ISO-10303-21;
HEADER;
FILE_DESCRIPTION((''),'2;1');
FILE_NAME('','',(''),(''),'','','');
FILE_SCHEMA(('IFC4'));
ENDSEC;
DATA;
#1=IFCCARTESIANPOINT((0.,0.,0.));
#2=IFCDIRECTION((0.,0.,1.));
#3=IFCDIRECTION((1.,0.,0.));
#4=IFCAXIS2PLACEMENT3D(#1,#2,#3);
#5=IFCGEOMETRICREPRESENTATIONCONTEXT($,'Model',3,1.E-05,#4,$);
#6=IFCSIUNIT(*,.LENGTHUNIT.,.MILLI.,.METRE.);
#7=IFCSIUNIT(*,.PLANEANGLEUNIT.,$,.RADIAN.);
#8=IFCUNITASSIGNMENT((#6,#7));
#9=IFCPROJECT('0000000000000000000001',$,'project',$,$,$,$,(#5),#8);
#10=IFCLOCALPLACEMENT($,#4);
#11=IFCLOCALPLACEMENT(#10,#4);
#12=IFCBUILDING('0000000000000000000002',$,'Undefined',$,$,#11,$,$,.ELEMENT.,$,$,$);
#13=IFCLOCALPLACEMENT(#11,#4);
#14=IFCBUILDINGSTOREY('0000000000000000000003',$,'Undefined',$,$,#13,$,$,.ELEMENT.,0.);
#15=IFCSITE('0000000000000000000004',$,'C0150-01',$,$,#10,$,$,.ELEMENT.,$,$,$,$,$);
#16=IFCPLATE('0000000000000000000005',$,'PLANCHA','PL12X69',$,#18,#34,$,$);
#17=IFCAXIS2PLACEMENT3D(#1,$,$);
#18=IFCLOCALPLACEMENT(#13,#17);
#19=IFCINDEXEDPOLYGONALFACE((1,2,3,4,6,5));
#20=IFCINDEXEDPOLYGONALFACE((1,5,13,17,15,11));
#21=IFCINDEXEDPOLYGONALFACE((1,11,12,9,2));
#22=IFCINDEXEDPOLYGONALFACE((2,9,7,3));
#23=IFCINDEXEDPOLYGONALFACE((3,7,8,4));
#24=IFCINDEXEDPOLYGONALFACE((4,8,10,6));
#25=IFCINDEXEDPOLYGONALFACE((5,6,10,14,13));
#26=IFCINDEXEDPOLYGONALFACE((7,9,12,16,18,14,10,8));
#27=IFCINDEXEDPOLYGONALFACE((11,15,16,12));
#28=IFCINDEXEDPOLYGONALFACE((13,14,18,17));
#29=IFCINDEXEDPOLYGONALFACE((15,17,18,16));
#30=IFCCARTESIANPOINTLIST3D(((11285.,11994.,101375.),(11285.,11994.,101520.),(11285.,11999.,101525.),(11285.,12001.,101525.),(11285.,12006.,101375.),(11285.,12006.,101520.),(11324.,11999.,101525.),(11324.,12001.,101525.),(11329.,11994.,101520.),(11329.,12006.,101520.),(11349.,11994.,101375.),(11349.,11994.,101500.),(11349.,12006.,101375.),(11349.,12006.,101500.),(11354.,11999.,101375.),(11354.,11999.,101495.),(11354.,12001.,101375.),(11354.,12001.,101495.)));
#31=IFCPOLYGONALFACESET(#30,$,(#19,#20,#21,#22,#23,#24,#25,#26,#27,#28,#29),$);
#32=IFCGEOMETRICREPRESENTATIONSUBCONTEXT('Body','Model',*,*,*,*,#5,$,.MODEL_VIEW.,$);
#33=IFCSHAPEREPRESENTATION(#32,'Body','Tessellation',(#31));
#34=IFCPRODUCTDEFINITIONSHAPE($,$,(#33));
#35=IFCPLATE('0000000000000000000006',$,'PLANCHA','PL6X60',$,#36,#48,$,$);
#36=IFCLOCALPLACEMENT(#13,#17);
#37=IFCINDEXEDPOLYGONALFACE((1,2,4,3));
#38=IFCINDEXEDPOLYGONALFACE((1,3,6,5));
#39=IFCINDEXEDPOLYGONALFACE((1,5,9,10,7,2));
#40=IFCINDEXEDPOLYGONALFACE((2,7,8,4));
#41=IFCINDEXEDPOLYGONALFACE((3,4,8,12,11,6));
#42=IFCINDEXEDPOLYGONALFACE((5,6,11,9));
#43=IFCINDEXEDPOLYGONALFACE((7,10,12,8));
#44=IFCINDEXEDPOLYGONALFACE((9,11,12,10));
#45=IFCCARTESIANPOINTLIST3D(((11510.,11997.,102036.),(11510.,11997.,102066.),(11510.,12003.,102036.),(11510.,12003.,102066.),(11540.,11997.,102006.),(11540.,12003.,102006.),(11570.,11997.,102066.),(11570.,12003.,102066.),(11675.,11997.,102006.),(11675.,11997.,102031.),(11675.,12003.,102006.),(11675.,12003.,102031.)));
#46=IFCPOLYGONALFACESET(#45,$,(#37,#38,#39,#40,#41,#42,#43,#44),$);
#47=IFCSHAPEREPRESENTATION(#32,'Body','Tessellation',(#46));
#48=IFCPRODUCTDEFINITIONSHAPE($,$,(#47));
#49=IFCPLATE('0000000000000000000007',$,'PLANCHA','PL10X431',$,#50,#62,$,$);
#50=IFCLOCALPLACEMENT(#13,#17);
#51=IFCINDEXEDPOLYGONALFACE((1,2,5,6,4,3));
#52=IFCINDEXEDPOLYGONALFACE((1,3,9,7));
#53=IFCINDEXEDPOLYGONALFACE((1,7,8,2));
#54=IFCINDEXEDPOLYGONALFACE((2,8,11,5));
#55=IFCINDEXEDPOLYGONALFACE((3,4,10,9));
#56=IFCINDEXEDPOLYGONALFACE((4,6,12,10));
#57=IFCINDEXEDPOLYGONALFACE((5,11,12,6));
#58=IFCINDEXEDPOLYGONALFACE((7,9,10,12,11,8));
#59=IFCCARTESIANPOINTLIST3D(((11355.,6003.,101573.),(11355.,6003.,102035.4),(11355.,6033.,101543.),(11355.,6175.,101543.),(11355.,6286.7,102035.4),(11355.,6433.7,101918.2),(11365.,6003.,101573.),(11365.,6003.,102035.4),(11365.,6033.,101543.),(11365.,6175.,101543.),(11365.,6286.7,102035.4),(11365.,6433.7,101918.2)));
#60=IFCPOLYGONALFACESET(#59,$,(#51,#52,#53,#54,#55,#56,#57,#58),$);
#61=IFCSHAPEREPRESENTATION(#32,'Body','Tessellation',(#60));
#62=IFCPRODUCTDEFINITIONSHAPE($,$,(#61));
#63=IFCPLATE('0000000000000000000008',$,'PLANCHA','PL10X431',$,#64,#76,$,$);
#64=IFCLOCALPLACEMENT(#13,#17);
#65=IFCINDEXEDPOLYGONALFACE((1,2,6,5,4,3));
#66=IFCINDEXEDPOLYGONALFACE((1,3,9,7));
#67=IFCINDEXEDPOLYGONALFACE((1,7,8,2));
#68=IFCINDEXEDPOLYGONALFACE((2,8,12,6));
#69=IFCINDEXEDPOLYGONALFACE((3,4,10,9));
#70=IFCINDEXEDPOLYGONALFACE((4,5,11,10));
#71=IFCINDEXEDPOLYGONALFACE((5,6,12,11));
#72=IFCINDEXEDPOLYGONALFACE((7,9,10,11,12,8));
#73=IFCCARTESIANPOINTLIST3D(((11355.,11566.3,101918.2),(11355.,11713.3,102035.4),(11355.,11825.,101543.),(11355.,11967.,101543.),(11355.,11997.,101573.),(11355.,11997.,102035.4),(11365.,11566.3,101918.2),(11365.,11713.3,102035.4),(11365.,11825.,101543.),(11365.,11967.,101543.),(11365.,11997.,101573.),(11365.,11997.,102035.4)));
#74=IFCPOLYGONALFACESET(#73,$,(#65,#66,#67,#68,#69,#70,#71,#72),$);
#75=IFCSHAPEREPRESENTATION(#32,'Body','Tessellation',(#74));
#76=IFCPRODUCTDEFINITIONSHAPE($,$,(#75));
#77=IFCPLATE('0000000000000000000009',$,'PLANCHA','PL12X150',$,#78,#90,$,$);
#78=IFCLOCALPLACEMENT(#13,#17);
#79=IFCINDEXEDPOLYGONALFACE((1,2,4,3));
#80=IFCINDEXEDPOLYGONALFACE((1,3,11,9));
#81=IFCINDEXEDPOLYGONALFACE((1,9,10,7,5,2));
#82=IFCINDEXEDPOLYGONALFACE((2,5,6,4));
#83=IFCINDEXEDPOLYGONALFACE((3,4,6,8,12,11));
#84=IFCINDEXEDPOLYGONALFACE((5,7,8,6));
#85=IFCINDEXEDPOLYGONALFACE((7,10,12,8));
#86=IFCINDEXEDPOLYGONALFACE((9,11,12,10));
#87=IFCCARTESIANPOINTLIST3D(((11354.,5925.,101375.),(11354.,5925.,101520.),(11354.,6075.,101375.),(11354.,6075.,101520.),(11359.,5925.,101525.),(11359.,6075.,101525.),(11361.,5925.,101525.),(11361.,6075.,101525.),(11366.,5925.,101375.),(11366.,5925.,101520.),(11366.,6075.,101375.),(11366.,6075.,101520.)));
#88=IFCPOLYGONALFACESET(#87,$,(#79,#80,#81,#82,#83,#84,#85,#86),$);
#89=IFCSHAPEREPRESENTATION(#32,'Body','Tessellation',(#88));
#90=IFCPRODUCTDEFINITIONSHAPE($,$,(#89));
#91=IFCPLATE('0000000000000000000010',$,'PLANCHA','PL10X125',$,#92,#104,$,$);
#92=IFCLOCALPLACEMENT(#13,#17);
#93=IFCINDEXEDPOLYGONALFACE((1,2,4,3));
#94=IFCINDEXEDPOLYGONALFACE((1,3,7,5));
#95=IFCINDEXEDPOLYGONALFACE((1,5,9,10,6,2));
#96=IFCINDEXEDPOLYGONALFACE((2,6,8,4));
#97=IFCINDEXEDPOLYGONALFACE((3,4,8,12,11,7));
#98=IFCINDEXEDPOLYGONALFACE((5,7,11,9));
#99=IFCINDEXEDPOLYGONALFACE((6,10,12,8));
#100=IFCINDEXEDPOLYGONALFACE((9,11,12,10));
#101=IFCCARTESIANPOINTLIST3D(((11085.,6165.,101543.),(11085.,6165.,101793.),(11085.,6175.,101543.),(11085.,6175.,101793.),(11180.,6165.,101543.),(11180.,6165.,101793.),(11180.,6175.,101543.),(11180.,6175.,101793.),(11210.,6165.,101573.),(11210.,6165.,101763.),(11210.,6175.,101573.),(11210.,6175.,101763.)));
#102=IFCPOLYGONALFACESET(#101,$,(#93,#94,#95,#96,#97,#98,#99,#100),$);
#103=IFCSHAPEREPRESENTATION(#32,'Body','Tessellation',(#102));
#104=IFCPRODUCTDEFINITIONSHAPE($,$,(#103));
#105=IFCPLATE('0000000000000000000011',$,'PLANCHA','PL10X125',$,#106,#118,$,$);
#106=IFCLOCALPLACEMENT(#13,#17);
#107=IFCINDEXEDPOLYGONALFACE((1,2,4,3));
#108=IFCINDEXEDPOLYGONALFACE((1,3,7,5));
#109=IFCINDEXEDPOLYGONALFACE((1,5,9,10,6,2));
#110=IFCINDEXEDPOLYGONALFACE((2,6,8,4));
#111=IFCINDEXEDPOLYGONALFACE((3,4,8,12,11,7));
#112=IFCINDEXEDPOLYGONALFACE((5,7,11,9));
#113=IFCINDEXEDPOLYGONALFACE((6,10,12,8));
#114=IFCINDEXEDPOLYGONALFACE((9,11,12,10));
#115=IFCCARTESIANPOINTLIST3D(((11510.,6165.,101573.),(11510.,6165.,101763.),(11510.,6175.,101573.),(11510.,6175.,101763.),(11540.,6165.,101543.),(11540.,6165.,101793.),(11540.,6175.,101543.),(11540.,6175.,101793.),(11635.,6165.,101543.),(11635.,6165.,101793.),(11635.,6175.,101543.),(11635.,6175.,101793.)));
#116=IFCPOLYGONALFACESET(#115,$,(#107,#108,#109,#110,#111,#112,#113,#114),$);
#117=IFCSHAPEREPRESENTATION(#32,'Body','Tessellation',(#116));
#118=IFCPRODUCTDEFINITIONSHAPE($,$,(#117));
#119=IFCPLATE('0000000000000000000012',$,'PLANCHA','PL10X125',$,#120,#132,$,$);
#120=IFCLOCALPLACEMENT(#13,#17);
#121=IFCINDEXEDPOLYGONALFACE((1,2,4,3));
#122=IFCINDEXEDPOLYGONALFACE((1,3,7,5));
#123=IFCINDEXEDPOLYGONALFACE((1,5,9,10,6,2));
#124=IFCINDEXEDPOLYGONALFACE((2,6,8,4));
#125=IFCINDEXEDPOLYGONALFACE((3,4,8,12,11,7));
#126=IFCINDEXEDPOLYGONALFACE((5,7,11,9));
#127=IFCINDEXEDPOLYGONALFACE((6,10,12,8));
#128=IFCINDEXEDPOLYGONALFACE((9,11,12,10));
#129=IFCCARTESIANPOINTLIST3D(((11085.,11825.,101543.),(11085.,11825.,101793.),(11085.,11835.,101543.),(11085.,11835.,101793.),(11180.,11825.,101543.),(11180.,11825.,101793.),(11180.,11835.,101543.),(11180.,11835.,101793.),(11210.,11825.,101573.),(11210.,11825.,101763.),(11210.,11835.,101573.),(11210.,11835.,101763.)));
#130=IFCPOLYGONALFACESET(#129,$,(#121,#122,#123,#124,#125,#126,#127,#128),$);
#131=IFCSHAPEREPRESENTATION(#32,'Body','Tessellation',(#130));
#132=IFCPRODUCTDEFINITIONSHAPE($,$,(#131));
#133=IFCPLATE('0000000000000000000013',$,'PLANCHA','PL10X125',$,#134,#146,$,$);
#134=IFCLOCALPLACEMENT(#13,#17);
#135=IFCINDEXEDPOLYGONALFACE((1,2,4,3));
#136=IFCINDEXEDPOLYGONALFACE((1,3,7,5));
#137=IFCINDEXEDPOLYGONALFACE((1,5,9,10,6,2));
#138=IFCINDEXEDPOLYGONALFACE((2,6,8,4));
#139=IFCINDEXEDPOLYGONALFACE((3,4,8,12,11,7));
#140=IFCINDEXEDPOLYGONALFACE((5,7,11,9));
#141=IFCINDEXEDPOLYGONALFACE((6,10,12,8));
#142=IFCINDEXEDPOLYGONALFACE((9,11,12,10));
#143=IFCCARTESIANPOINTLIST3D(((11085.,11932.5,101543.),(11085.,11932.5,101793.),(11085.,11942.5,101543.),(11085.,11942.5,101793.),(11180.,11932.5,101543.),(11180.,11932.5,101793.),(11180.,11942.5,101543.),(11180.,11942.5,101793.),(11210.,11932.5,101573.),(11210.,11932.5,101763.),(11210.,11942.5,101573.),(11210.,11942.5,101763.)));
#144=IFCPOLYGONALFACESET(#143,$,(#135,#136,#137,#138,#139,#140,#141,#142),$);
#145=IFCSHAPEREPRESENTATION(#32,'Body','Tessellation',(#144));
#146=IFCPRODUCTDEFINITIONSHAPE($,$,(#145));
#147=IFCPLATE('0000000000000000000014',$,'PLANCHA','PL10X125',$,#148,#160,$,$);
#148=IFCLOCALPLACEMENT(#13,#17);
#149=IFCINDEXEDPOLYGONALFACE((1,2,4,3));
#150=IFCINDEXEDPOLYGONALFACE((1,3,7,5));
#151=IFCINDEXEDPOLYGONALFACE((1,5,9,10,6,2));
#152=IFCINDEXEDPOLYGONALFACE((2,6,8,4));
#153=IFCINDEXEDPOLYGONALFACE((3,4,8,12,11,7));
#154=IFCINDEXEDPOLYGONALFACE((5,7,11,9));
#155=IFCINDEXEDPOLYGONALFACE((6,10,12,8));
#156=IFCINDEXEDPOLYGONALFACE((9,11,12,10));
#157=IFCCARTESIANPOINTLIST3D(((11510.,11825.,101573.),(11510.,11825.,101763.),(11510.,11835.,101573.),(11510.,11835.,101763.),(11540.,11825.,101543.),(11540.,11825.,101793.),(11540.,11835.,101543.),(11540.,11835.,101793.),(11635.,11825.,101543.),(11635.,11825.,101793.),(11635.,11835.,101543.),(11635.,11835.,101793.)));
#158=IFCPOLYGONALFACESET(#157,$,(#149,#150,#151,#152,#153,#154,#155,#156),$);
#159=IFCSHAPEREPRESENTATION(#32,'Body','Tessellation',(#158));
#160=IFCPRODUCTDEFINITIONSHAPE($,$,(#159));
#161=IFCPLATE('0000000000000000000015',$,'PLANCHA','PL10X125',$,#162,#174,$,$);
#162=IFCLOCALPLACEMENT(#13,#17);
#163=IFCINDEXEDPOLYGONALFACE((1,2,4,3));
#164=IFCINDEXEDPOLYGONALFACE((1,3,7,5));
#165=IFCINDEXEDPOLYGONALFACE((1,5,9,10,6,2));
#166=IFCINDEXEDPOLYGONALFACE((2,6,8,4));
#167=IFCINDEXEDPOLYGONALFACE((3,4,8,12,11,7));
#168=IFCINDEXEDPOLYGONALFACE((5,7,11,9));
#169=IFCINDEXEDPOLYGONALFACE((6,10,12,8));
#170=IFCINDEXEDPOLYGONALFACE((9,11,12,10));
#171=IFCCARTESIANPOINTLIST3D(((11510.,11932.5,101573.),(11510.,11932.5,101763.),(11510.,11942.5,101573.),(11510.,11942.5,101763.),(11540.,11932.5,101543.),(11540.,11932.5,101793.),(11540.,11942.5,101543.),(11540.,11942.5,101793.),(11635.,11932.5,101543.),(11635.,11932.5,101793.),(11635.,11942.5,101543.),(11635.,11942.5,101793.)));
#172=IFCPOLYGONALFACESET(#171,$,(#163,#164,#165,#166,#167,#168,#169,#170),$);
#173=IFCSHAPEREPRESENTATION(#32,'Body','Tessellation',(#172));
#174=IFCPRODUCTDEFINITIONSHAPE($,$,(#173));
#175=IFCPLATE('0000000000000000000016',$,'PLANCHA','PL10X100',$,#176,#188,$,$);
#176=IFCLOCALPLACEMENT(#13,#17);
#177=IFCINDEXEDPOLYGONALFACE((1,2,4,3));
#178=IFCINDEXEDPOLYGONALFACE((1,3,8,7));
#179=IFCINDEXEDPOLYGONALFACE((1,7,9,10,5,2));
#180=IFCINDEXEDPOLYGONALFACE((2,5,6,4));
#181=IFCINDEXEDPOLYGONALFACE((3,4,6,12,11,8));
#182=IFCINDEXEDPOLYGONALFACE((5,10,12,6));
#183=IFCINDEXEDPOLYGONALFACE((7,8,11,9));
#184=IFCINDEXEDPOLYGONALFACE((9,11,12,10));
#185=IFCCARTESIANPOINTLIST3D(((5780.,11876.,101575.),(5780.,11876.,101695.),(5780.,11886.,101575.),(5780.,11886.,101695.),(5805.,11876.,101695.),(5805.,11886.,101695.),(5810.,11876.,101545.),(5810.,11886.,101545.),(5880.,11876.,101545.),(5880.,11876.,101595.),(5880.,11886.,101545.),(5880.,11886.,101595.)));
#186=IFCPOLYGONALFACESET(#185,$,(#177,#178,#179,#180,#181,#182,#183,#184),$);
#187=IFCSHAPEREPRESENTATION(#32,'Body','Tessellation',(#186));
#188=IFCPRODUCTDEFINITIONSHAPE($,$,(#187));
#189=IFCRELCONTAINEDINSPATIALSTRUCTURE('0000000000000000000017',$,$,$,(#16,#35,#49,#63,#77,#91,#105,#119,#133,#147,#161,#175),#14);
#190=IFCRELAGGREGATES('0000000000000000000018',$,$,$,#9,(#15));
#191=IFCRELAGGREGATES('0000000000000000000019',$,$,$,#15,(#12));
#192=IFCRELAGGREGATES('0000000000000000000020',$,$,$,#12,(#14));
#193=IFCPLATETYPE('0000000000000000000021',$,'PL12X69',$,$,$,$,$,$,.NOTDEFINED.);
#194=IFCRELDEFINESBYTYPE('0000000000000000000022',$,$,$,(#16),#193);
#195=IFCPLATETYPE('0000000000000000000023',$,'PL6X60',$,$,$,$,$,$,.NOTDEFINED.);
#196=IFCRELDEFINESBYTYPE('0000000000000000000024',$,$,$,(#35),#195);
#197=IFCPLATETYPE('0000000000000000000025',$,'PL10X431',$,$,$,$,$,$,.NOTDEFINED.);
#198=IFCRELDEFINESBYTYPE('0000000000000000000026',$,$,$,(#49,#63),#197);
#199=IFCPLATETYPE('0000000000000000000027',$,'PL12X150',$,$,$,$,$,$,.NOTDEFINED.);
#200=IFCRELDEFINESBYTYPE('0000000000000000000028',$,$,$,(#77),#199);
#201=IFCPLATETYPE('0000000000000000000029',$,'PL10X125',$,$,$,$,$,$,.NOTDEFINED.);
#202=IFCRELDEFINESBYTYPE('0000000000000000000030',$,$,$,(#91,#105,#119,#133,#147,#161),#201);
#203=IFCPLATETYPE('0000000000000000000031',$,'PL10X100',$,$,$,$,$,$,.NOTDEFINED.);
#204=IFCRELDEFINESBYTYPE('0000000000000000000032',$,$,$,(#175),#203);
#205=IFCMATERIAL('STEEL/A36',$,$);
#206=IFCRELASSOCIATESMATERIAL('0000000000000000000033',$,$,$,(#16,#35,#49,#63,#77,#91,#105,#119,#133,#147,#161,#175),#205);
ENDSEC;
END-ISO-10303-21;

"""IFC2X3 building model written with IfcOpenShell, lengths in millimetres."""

from ifc_helpers import new_model, si_unit, frame, origin_with_axes, place, context, subcontext, project, spatial, polyline, outline, extrude, boolean, material, type_object, element, save


model = new_model("IFC2X3")

# Units and contexts
model_context = context("Model", 3, precision=1e-05, world=origin_with_axes())
body_context = subcontext(model_context, "Body", "Model", "MODEL_VIEW")
ifc_project = project(units=[si_unit("LENGTHUNIT", "METRE", prefix="MILLI"), si_unit("PLANEANGLEUNIT", "RADIAN")], contexts=[model_context])

# Site, building, storey
site_placement = place(None, origin_with_axes())
site = spatial("IfcSite", under=ifc_project, at=site_placement, Name="C0150-01", CompositionType="ELEMENT")
building_placement = place(site_placement, origin_with_axes())
building = spatial("IfcBuilding", under=site, at=building_placement, Name="Undefined", CompositionType="ELEMENT")
storey_placement = place(building_placement, origin_with_axes())
storey = spatial("IfcBuildingStorey", under=building, at=storey_placement, Name="Undefined", CompositionType="ELEMENT", Elevation=0.0)

# Shared definitions
ifc_material_1 = material(Name="STEEL/A36")

# Plates
plate_type_1 = type_object("IfcPlateType", Name="PL12X69", PredefinedType="NOTDEFINED")
plate_1_placement = place(storey_placement, frame((11285.0, 12000.0, 101525.0), z_axis=(0.0, -1.0, 0.0), x_axis=(0.0, 0.0, -1.0)))
element("IfcPlate", 1, at=plate_1_placement, inside=storey, type_object=plate_type_1, material=ifc_material_1, Name="PLANCHA", Description="PL12X69", context=body_context, shape_type="CSG", body=[
    boolean("DIFFERENCE", boolean("DIFFERENCE", boolean("DIFFERENCE", boolean("DIFFERENCE", extrude(outline(polyline([(0.0, 0.0), (150.0, 0.0), (150.0, 69.0), (30.0, 69.0), (0.0, 39.0), (0.0, 0.0)])), frame((0.0, 0.0, -6.0), z_axis=(0.0, 0.0, 1.0), x_axis=(1.0, 0.0, 0.0)), (0.0, 0.0, 1.0), 12.0), extrude(outline(polyline([(0.0, 0.0), (5.0, 0.0), (5.0, 5.0), (0.0, 0.0)])), frame((152.5, 69.0, -1.0), z_axis=(-1.0, 0.0, 0.0), x_axis=(0.0, 0.0, -1.0)), (0.0, 0.0, 1.0), 155.0)), extrude(outline(polyline([(0.0, 0.0), (5.0, 0.0), (5.0, 5.0), (0.0, 0.0)])), frame((-2.5, 69.0, 1.0), z_axis=(1.0, 0.0, 0.0), x_axis=(0.0, 0.0, 1.0)), (0.0, 0.0, 1.0), 155.0)), extrude(outline(polyline([(0.0, 0.0), (5.0, 0.0), (5.0, 5.0), (0.0, 0.0)])), frame((0.0, 71.5, -1.0), z_axis=(0.0, -1.0, 0.0), x_axis=(0.0, 0.0, -1.0)), (0.0, 0.0, 1.0), 101.0)), extrude(outline(polyline([(0.0, 0.0), (5.0, 0.0), (5.0, 5.0), (0.0, 0.0)])), frame((0.0, -29.5, 1.0), z_axis=(0.0, 1.0, 0.0), x_axis=(0.0, 0.0, 1.0)), (0.0, 0.0, 1.0), 101.0)),
])
plate_type_2 = type_object("IfcPlateType", Name="PL6X60", PredefinedType="NOTDEFINED")
plate_2_placement = place(storey_placement, frame((11675.0, 12000.0, 102031.0), z_axis=(0.0, 1.0, 0.0), x_axis=(0.000005, 0.0, -1.0)))
element("IfcPlate", 2, at=plate_2_placement, inside=storey, type_object=plate_type_2, material=ifc_material_1, Name="PLANCHA", Description="PL6X60", context=body_context, shape_type="SweptSolid", body=[
    extrude(outline(polyline([(0.0, 0.0), (25.0, 0.0), (25.0, 135.0), (-5.0, 165.0), (-35.0, 165.0), (-35.0, 105.0), (0.0, 0.0)])), frame((0.0, 0.0, -3.0), z_axis=(0.0, 0.0, 1.0), x_axis=(1.0, 0.0, 0.0)), (0.0, 0.0, 1.0), 6.0),
])
plate_type_3 = type_object("IfcPlateType", Name="PL10X431", PredefinedType="NOTDEFINED")
for number, where, z_axis, x_axis, name in (
    (3, (11360.0, 6433.7, 101918.2), (-1.0, 0.0, 0.0), (0.0, -0.567638, -0.823279), "PLANCHA"),
    (4, (11360.0, 11566.3, 101918.2), (1.0, 0.0, 0.0), (0.0, 0.567638, -0.823279), "PLANCHA"),
):
    element("IfcPlate", number, at=place(storey_placement, frame(where, z_axis=z_axis, x_axis=x_axis)), inside=storey, type_object=plate_type_3, material=ifc_material_1, Name=name, Description="PL10X431", context=body_context, shape_type="SweptSolid", body=[
        extrude(outline(polyline([(0.0, 0.0), (455.8, 0.0), (536.4, 116.9), (528.7, 158.6), (148.0, 421.1), (-13.0, 187.5), (0.0, 0.0)])), frame((0.0, 0.0, -5.0), z_axis=(0.0, 0.0, 1.0), x_axis=(1.0, 0.0, 0.0)), (0.0, 0.0, 1.0), 10.0),
    ])
plate_type_4 = type_object("IfcPlateType", Name="PL12X150", PredefinedType="NOTDEFINED")
plate_3_placement = place(storey_placement, frame((11360.0, 6075.0, 101525.0), z_axis=(-1.0, 0.0, 0.0), x_axis=(0.0, 0.0, -1.0)))
element("IfcPlate", 5, at=plate_3_placement, inside=storey, type_object=plate_type_4, material=ifc_material_1, Name="PLANCHA", Description="PL12X150", context=body_context, shape_type="CSG", body=[
    boolean("DIFFERENCE", boolean("DIFFERENCE", extrude(outline(polyline([(0.0, 0.0), (150.0, 0.0), (150.0, 150.0), (0.0, 150.0), (0.0, 0.0)])), frame((0.0, 0.0, -6.0), z_axis=(0.0, 0.0, 1.0), x_axis=(1.0, 0.0, 0.0)), (0.0, 0.0, 1.0), 12.0), extrude(outline(polyline([(0.0, 0.0), (5.0, 0.0), (5.0, 5.0), (0.0, 0.0)])), frame((5.0, 152.5, 6.0), z_axis=(0.0, -1.0, 0.0), x_axis=(-1.0, 0.0, 0.0)), (0.0, 0.0, 1.0), 155.0)), extrude(outline(polyline([(0.0, 0.0), (5.0, 0.0), (5.0, 5.0), (0.0, 0.0)])), frame((5.0, -2.5, -6.0), z_axis=(0.0, 1.0, 0.0), x_axis=(-1.0, 0.0, 0.0)), (0.0, 0.0, 1.0), 155.0)),
])
plate_type_5 = type_object("IfcPlateType", Name="PL10X125", PredefinedType="NOTDEFINED")
for number, where, z_axis, x_axis, name in (
    (6, (11085.0, 6170.0, 101793.0), (0.0, -1.0, 0.0), (0.0, 0.0, -1.0), "PLANCHA"),
    (7, (11635.0, 6170.0, 101793.0), (0.0, 1.0, 0.0), (0.0, 0.0, -1.0), "PLANCHA"),
    (8, (11085.0, 11830.0, 101793.0), (0.0, -1.0, 0.0), (0.0, 0.0, -1.0), "PLANCHA"),
    (9, (11085.0, 11937.5, 101793.0), (0.0, -1.0, 0.0), (0.0, 0.0, -1.0), "PLANCHA"),
    (10, (11635.0, 11830.0, 101793.0), (0.0, 1.0, 0.0), (0.0, 0.0, -1.0), "PLANCHA"),
    (11, (11635.0, 11937.5, 101793.0), (0.0, 1.0, 0.0), (0.0, 0.0, -1.0), "PLANCHA"),
):
    element("IfcPlate", number, at=place(storey_placement, frame(where, z_axis=z_axis, x_axis=x_axis)), inside=storey, type_object=plate_type_5, material=ifc_material_1, Name=name, Description="PL10X125", context=body_context, shape_type="SweptSolid", body=[
        extrude(outline(polyline([(0.0, 0.0), (250.0, 0.0), (250.0, 95.0), (220.0, 125.0), (30.0, 125.0), (0.0, 95.0), (0.0, 0.0)])), frame((0.0, 0.0, -5.0), z_axis=(0.0, 0.0, 1.0), x_axis=(1.0, 0.0, 0.0)), (0.0, 0.0, 1.0), 10.0),
    ])
plate_type_6 = type_object("IfcPlateType", Name="PL10X100", PredefinedType="NOTDEFINED")
plate_4_placement = place(storey_placement, frame((5880.0, 11881.0, 101545.0), z_axis=(0.0, 1.0, 0.0), x_axis=(-1.0, 0.0, 0.0)))
element("IfcPlate", 12, at=plate_4_placement, inside=storey, type_object=plate_type_6, material=ifc_material_1, Name="PLANCHA", Description="PL10X100", context=body_context, shape_type="SweptSolid", body=[
    extrude(outline(polyline([(0.0, 0.0), (70.0, 0.0), (100.0, 30.0), (100.0, 150.0), (75.0, 150.0), (0.0, 50.0), (0.0, 0.0)])), frame((0.0, 0.0, -5.0), z_axis=(0.0, 0.0, 1.0), x_axis=(1.0, 0.0, 0.0)), (0.0, 0.0, 1.0), 10.0),
])

save(model, "model.ifc")
